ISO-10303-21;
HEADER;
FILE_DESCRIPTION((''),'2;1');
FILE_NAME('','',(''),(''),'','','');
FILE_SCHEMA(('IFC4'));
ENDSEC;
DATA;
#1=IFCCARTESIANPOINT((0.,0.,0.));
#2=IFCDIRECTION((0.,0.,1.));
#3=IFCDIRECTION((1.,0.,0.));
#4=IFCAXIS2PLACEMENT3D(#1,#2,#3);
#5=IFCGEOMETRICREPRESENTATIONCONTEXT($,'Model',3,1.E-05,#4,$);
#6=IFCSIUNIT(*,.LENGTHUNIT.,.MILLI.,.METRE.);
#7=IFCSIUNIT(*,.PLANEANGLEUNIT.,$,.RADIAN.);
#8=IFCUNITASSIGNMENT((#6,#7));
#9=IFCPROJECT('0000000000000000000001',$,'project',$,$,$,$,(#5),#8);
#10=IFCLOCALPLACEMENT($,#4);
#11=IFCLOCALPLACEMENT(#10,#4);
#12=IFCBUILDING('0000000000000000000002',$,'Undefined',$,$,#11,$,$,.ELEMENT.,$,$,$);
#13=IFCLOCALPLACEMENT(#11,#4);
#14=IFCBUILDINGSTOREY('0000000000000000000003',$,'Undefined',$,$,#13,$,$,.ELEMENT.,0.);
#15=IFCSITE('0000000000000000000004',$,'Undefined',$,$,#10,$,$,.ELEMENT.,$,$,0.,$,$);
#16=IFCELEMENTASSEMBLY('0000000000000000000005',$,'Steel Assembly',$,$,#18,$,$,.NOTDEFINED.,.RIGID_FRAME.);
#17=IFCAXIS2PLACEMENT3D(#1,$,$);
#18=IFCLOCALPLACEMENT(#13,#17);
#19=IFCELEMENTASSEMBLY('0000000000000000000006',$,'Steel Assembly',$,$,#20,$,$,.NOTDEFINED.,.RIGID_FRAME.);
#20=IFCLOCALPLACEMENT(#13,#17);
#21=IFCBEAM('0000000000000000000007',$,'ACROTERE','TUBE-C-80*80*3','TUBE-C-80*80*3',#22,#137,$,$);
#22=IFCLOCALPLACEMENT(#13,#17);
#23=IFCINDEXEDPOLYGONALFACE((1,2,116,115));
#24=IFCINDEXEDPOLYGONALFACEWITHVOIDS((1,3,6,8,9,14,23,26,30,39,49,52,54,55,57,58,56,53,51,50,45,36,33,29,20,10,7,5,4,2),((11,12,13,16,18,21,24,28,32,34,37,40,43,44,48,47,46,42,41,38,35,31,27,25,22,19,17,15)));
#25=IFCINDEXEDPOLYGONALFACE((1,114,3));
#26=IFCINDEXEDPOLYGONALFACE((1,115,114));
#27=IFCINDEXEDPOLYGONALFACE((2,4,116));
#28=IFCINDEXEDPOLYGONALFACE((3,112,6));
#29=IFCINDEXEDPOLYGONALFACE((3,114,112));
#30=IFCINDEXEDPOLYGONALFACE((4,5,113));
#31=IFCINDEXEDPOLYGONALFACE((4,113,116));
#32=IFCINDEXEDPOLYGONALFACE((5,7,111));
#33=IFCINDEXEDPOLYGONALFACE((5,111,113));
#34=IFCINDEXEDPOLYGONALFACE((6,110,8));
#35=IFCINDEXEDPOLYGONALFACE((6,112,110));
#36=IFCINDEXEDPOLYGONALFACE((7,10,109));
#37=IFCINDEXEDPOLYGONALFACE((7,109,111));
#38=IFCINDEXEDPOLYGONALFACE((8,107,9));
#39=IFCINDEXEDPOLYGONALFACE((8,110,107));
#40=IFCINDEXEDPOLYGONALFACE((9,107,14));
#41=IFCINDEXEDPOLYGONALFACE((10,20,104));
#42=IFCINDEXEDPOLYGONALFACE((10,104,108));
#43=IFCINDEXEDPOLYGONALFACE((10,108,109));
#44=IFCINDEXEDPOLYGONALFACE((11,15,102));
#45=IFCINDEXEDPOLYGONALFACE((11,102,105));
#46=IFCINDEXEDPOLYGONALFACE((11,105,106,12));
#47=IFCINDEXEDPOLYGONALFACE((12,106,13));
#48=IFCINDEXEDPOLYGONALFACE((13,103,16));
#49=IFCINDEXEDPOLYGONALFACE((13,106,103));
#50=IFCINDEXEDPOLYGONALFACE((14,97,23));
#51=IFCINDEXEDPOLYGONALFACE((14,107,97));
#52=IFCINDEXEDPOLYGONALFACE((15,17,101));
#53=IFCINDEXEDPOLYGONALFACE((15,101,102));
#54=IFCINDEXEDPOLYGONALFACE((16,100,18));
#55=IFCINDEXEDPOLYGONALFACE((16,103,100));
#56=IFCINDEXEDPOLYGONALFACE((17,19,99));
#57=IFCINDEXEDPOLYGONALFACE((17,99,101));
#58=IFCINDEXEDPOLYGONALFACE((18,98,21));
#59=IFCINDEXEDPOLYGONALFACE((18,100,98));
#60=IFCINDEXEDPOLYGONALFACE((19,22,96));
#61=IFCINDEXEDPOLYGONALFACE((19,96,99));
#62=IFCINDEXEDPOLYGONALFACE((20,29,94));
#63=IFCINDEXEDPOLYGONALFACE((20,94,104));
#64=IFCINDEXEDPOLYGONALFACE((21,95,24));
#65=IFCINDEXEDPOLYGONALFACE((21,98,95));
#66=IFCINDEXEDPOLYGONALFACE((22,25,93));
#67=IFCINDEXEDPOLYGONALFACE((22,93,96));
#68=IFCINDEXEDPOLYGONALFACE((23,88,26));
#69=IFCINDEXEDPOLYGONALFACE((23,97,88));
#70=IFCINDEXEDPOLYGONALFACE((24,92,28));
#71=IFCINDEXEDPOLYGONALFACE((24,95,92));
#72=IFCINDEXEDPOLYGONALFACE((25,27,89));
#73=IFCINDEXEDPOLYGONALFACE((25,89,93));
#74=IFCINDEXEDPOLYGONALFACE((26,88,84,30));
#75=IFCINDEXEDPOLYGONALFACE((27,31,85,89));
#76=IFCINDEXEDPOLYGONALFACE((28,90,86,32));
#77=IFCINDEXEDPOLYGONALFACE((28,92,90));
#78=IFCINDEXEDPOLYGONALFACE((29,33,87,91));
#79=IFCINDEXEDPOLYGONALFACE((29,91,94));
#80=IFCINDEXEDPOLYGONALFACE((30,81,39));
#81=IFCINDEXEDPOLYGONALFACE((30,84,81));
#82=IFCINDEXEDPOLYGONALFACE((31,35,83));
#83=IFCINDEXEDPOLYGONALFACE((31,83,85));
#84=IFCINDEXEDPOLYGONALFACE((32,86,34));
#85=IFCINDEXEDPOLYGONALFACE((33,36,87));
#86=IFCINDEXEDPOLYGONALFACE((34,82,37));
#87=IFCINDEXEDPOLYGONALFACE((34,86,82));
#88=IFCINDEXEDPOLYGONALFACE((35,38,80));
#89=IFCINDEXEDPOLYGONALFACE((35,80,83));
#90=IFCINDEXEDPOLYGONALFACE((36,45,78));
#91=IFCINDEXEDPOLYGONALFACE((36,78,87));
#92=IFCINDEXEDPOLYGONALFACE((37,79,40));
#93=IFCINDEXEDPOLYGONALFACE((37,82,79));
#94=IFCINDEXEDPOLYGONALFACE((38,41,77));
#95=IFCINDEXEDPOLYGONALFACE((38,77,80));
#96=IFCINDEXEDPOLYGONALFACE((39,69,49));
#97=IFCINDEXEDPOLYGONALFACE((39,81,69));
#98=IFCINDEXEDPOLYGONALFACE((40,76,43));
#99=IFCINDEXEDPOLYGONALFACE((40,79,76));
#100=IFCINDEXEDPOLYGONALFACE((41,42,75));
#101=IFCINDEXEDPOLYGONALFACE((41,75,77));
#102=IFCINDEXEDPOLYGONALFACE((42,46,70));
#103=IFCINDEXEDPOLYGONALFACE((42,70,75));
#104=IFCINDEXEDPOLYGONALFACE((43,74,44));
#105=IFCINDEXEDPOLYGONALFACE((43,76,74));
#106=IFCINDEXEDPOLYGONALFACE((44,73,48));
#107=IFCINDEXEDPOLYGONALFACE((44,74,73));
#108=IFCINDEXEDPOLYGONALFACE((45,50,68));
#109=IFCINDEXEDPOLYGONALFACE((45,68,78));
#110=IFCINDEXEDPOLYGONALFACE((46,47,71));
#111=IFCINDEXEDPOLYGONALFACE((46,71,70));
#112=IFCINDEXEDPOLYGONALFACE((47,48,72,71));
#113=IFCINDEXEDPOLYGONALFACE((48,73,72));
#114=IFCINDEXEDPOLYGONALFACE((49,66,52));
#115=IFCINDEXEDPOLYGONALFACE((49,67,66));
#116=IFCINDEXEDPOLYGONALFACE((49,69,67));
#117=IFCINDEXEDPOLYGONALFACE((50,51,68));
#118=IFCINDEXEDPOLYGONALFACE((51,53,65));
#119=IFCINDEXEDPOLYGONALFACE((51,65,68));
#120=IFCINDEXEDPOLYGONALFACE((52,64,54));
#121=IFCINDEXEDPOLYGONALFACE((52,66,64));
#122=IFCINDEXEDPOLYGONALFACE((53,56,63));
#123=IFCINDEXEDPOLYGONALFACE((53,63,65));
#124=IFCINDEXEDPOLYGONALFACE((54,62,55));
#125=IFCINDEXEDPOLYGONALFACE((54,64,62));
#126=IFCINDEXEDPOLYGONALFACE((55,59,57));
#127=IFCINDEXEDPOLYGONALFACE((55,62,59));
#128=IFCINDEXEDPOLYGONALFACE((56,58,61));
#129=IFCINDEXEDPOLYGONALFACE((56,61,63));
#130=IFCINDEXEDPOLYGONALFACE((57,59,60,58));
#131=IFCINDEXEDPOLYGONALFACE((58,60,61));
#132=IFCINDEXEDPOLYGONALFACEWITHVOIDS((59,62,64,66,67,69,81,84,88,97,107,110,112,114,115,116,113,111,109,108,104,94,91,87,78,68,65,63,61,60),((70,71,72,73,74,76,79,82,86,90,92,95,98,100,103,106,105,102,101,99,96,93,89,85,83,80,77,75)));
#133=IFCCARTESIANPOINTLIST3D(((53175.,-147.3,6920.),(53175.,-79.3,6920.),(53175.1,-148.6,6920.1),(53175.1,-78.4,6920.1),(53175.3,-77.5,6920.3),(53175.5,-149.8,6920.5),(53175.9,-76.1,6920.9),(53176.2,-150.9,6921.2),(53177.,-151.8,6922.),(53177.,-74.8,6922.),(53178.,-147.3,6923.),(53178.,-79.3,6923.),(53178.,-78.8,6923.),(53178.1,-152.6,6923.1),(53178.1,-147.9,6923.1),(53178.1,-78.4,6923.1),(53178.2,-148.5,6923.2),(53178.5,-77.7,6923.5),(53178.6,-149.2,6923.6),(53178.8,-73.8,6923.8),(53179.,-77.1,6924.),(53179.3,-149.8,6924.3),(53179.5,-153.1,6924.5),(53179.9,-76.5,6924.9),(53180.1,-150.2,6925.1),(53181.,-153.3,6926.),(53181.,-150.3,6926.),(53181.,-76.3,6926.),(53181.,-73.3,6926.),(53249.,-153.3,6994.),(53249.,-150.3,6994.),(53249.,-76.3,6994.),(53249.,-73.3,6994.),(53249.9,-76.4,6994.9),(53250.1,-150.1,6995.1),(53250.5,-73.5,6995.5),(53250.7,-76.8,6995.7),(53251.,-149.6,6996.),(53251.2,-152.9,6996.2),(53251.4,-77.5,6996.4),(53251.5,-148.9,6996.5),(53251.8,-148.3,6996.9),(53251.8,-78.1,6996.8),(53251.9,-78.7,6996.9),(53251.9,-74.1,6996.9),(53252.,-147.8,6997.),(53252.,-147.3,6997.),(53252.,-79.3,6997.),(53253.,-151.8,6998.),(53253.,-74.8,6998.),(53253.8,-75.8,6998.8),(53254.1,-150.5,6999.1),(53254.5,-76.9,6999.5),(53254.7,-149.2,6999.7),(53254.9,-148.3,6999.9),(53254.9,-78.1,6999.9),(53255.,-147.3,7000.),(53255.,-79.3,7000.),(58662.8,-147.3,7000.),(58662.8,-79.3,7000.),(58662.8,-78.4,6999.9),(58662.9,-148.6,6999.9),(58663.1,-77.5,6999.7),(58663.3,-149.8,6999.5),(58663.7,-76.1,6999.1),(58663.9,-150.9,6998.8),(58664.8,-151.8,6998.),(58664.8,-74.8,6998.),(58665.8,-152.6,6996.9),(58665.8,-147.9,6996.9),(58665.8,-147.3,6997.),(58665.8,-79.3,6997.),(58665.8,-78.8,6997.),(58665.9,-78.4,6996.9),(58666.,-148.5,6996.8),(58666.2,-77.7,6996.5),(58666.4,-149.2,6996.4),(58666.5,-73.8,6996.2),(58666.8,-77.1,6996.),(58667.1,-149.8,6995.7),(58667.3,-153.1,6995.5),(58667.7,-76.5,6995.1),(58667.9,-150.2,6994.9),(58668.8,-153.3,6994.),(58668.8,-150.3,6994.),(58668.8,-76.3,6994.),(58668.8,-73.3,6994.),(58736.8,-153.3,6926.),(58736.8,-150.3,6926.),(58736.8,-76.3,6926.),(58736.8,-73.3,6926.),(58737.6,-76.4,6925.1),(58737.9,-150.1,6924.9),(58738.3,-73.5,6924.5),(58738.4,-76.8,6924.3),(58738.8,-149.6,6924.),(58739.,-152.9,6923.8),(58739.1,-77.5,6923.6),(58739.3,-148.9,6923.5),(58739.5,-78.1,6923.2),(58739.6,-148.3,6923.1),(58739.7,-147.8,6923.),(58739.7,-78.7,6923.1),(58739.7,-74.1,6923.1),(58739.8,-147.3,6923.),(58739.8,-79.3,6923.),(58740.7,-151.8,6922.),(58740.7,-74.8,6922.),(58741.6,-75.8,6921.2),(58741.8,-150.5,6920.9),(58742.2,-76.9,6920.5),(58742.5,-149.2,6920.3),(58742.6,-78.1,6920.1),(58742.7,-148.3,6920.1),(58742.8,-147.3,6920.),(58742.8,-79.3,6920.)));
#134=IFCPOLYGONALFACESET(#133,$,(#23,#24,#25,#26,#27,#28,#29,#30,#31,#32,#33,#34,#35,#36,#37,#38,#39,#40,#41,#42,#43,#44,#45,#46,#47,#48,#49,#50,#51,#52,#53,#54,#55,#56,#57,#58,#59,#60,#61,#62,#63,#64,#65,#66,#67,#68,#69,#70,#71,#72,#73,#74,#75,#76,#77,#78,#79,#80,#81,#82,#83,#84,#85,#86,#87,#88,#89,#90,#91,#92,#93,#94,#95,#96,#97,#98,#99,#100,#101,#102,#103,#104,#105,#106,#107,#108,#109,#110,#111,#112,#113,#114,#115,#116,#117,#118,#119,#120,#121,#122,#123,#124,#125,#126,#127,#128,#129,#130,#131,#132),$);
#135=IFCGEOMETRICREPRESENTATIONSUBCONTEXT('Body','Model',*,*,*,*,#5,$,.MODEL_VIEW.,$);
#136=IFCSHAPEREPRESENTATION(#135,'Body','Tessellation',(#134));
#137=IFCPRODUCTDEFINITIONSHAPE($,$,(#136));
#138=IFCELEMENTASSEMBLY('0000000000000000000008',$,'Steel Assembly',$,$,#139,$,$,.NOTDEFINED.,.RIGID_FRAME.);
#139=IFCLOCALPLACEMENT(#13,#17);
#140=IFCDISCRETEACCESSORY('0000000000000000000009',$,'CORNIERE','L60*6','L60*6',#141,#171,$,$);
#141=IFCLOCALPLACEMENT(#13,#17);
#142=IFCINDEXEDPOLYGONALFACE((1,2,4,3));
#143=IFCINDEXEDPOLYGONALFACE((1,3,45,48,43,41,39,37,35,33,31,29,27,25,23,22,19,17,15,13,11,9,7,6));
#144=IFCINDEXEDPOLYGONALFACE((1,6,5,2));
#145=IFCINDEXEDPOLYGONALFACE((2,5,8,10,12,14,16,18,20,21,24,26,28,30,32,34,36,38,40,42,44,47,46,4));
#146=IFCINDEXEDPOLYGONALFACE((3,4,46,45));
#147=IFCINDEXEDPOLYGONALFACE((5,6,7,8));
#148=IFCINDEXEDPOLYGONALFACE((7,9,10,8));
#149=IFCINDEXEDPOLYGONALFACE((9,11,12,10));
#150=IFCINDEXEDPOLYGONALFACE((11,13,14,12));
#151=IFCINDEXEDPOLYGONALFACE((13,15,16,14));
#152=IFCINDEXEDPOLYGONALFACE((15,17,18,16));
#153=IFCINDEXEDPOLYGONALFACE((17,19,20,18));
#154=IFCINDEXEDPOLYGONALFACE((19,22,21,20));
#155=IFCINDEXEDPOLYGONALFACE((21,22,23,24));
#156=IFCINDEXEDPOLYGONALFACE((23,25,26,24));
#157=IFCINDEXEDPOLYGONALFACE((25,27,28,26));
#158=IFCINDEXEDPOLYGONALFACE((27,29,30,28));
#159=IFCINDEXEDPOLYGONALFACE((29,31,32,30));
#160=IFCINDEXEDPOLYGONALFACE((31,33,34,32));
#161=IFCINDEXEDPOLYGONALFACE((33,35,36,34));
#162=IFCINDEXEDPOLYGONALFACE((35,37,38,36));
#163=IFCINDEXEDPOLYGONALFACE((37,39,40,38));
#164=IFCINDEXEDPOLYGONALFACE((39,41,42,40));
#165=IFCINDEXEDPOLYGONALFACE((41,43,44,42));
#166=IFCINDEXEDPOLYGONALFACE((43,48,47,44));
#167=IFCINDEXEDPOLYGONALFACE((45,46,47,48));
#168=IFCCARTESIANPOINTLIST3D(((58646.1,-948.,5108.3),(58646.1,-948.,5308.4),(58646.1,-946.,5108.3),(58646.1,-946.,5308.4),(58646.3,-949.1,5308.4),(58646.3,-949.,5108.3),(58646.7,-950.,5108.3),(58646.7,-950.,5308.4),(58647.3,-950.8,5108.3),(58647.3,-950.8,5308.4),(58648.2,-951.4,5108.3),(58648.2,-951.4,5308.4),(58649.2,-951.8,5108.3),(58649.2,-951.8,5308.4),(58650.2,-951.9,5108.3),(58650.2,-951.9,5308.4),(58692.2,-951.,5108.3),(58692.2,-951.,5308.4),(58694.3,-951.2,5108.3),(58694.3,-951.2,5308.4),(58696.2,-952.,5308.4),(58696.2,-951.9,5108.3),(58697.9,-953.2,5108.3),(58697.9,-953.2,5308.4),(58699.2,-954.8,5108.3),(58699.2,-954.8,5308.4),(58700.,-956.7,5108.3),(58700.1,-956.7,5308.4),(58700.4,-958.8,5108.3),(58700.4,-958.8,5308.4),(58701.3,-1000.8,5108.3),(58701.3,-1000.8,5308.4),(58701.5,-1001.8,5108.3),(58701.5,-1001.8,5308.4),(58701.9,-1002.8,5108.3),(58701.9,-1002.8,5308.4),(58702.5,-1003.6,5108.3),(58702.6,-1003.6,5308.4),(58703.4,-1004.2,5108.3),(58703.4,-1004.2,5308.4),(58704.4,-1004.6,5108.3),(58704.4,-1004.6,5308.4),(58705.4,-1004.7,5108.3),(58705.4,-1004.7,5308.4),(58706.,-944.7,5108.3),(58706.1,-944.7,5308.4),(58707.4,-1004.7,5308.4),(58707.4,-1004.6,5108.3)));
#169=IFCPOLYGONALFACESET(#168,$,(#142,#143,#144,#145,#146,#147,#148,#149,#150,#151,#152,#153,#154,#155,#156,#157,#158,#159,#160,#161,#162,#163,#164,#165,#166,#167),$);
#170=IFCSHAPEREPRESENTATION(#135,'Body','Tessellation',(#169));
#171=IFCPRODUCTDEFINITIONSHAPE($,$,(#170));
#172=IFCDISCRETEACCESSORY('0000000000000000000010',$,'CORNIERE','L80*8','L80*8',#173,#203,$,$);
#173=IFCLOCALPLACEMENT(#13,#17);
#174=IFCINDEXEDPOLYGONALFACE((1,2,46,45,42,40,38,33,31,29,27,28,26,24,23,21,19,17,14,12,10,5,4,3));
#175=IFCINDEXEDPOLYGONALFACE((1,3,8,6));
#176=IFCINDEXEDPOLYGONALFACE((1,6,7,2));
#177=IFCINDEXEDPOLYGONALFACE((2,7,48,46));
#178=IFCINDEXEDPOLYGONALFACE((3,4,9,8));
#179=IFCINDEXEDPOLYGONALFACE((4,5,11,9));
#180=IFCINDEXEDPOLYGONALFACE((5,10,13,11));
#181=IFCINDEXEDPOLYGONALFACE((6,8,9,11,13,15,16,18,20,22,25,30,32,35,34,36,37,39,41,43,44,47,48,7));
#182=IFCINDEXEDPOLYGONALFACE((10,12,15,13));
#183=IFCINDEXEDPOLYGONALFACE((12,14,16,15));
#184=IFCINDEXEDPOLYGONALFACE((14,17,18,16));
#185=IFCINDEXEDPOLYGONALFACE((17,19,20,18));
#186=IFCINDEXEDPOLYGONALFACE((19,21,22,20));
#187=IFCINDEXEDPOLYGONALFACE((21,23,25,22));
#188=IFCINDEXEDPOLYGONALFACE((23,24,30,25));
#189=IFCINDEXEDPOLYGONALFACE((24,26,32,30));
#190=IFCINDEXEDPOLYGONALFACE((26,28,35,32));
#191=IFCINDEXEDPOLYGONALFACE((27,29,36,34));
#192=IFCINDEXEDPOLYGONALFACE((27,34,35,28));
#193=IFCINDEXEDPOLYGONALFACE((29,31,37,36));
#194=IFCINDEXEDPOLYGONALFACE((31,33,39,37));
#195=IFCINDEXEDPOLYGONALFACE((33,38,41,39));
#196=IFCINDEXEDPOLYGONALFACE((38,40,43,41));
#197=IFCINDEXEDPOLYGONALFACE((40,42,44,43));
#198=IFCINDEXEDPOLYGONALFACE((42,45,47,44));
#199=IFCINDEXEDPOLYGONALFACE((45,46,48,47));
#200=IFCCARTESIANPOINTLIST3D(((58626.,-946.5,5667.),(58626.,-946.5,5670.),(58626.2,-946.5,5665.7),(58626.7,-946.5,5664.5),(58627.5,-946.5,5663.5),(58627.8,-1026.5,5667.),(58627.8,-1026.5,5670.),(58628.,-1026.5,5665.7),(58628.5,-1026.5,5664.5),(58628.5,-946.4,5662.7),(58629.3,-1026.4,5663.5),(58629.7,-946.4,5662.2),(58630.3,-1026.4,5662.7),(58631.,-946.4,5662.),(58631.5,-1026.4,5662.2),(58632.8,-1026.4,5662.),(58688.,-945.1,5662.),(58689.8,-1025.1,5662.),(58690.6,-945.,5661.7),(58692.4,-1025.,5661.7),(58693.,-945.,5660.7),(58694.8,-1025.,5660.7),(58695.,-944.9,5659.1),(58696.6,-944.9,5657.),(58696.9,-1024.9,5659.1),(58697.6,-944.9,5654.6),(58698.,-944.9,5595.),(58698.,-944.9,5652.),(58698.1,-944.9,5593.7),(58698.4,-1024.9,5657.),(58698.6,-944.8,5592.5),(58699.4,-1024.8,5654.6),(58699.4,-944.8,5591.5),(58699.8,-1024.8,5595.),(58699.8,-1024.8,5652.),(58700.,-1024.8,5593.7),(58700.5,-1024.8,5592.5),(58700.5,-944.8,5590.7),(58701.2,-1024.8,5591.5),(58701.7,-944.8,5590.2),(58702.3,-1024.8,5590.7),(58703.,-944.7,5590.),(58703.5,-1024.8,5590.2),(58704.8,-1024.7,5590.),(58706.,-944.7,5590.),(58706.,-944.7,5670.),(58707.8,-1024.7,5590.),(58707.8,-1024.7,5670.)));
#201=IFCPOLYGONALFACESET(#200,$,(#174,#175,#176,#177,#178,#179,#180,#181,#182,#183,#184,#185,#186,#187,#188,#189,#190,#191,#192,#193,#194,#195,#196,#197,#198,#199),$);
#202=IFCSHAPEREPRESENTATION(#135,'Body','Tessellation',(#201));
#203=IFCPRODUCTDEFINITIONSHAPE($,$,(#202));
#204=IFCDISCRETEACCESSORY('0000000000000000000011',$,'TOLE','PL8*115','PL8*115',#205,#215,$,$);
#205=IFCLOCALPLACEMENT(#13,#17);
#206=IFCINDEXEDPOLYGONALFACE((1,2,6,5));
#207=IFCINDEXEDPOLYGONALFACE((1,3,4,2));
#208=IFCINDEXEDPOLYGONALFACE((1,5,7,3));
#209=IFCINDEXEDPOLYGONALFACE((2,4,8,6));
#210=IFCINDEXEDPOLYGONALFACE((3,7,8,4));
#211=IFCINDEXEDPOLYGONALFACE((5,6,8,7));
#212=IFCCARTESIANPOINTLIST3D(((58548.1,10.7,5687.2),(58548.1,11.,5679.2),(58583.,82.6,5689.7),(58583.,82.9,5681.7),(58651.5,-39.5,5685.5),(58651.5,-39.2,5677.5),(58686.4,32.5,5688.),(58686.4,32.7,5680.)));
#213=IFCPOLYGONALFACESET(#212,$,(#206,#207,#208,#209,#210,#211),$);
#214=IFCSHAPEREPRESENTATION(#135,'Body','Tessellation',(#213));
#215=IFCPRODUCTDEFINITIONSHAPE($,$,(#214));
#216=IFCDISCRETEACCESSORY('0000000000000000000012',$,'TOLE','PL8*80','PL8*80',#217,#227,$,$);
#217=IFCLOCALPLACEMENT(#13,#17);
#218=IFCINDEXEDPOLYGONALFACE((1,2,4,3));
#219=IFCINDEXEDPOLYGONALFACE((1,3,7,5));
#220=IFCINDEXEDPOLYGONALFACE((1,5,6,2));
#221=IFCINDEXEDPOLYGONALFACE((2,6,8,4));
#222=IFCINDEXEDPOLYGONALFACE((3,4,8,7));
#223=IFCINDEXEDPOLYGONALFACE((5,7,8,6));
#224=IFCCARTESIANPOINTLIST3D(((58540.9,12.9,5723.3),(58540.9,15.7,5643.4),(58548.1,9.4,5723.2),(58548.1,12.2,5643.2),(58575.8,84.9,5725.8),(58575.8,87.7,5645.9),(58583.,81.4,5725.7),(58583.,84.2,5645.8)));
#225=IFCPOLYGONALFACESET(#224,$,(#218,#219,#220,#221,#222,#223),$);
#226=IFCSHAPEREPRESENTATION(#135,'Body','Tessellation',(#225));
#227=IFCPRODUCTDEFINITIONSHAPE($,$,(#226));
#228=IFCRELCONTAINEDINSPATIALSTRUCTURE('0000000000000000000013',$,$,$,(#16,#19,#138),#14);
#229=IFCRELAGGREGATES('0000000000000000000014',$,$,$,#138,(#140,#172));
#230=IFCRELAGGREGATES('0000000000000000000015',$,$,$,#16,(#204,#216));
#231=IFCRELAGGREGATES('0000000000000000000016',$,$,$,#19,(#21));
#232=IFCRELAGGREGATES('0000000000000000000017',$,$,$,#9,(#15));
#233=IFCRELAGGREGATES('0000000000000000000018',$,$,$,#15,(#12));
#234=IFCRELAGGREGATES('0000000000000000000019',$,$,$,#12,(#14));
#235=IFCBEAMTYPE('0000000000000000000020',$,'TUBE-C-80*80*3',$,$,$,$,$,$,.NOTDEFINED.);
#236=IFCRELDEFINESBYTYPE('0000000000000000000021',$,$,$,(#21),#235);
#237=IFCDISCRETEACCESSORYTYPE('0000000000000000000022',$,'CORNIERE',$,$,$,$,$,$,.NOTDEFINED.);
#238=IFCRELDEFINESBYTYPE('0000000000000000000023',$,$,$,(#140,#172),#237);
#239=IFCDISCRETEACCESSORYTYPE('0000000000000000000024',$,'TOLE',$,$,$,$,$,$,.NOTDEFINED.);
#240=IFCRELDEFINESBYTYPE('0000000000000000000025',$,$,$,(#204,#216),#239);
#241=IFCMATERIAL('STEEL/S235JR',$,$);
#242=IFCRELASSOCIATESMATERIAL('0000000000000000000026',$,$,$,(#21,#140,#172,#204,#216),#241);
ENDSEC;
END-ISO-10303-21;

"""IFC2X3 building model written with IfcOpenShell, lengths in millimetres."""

from ifc_helpers import new_model, si_unit, frame, origin_with_axes, origin_2d_with_axis, place, context, subcontext, project, spatial, polyline, hollow_rectangle, l_section, outline, extrude, clip, halfspace, material, type_object, element, aggregate, save


model = new_model("IFC2X3")

# Units and contexts
model_context = context("Model", 3, precision=1e-05, world=origin_with_axes())
body_context = subcontext(model_context, "Body", "Model", "MODEL_VIEW")
ifc_project = project(units=[si_unit("LENGTHUNIT", "METRE", prefix="MILLI"), si_unit("PLANEANGLEUNIT", "RADIAN")], contexts=[model_context])

# Site, building, storey
site_placement = place(None, origin_with_axes())
site = spatial("IfcSite", under=ifc_project, at=site_placement, Name="Undefined", CompositionType="ELEMENT", RefElevation=0.0)
building_placement = place(site_placement, origin_with_axes())
building = spatial("IfcBuilding", under=site, at=building_placement, Name="Undefined", CompositionType="ELEMENT")
storey_placement = place(building_placement, origin_with_axes())
storey = spatial("IfcBuildingStorey", under=building, at=storey_placement, Name="Undefined", CompositionType="ELEMENT", Elevation=0.0)

# Element assemblies, beam
ifc_material_1 = material(Name="STEEL/S235JR")
beam_type_1 = type_object("IfcBeamType", Name="TUBE-C-80*80*3", PredefinedType="NOTDEFINED")
assembly_1_placement = place(storey_placement, origin_with_axes())
assembly_1 = element("IfcElementAssembly", 1, at=assembly_1_placement, inside=storey, Name="Steel Assembly", AssemblyPlace="NOTDEFINED", PredefinedType="RIGID_FRAME")
assembly_2_placement = place(storey_placement, origin_with_axes())
assembly_2 = element("IfcElementAssembly", 2, at=assembly_2_placement, inside=storey, Name="Steel Assembly", AssemblyPlace="NOTDEFINED", PredefinedType="RIGID_FRAME")
beam_1_placement = place(assembly_2_placement, frame((58747.8, -113.3, 6960.0), z_axis=(0.0, 0.0, -1.0), x_axis=(-1.0, 0.0, 0.0)))
beam_1 = element("IfcBeam", 3, at=beam_1_placement, type_object=beam_type_1, material=ifc_material_1, Name="ACROTERE", Description="TUBE-C-80*80*3", ObjectType="TUBE-C-80*80*3", context=body_context, shape_type="Clipping", body=[
    clip(clip(extrude(hollow_rectangle(XDim=80.0, YDim=80.0, WallThickness=3.0, InnerFilletRadius=3.0, OuterFilletRadius=6.0, at=origin_2d_with_axis()), frame((5577.8, 0.0, 0.0), z_axis=(-1.0, 0.0, 0.0), x_axis=(0.0, -1.0, 0.0)), (0.0, 0.0, 1.0), 5577.8), halfspace(frame((5.0, -40.0, 40.0), z_axis=(-0.707107, 0.0, -0.707107), x_axis=(0.707107, 0.0, -0.707107)), False)), halfspace(frame((5572.8, 40.0, 40.0), z_axis=(0.707107, 0.0, -0.707107), x_axis=(-0.707107, 0.0, -0.707107)), False)),
])

# Element assembly, discrete accessories
assembly_3_placement = place(storey_placement, origin_with_axes())
assembly_3 = element("IfcElementAssembly", 4, at=assembly_3_placement, inside=storey, Name="Steel Assembly", AssemblyPlace="NOTDEFINED", PredefinedType="RIGID_FRAME")
discrete_accessory_type_1 = type_object("IfcDiscreteAccessoryType", Name="CORNIERE")
discrete_accessory_1_placement = place(assembly_3_placement, frame((58676.7, -975.3, 5308.4), z_axis=(0.022588, -0.999745, -0.000079), x_axis=(-0.000026, 0.000079, -1.0)))
discrete_accessory_1 = element("IfcDiscreteAccessory", 5, at=discrete_accessory_1_placement, type_object=discrete_accessory_type_1, material=ifc_material_1, Name="CORNIERE", Description="L60*6", ObjectType="L60*6", context=body_context, shape_type="SweptSolid", body=[
    extrude(l_section(Depth=60.0, Width=60.0, Thickness=6.0, FilletRadius=8.0, EdgeRadius=4.0, at=origin_2d_with_axis()), frame((200.1, 0.0, 0.0), z_axis=(-1.0, 0.0, 0.0), x_axis=(0.0, -1.0, 0.0)), (0.0, 0.0, 1.0), 200.1),
])
discrete_accessory_2_placement = place(assembly_3_placement, frame((58667.8, -1025.6, 5630.0), z_axis=(0.0, 0.0, -1.0), x_axis=(-0.022588, 0.999745, -0.000001)))
discrete_accessory_2 = element("IfcDiscreteAccessory", 6, at=discrete_accessory_2_placement, type_object=discrete_accessory_type_1, material=ifc_material_1, Name="CORNIERE", Description="L80*8", ObjectType="L80*8", context=body_context, shape_type="SweptSolid", body=[
    extrude(l_section(Depth=80.0, Width=80.0, Thickness=8.0, FilletRadius=10.0, EdgeRadius=5.0, at=origin_2d_with_axis()), frame((80.0, 0.0, 0.0), z_axis=(-1.0, 0.0, 0.0), x_axis=(0.0, -1.0, 0.0)), (0.0, 0.0, 1.0), 80.0),
])

# Discrete accessories
discrete_accessory_type_2 = type_object("IfcDiscreteAccessoryType", Name="TOLE")
discrete_accessory_3_placement = place(assembly_1_placement, frame((58599.8, -14.2, 5682.3), z_axis=(0.0, 0.034979, -0.999388), x_axis=(0.436481, 0.899163, 0.031471)))
discrete_accessory_3 = element("IfcDiscreteAccessory", 7, at=discrete_accessory_3_placement, type_object=discrete_accessory_type_2, material=ifc_material_1, Name="TOLE", Description="PL8*115", ObjectType="PL8*115", context=body_context, shape_type="SweptSolid", body=[
    extrude(outline(polyline([(0.0, 57.5), (80.0, 57.5), (80.0, -57.5), (0.0, -57.5), (0.0, 57.5)])), frame((0.0, 0.0, -4.0), z_axis=(0.0, 0.0, 1.0), x_axis=(1.0, 0.0, 0.0)), (0.0, 0.0, 1.0), 8.0),
])
discrete_accessory_4_placement = place(assembly_1_placement, frame((58544.5, 12.6, 5683.3), z_axis=(0.899713, -0.436214, -0.015267), x_axis=(0.436481, 0.899163, 0.031471)))
discrete_accessory_4 = element("IfcDiscreteAccessory", 8, at=discrete_accessory_4_placement, type_object=discrete_accessory_type_2, material=ifc_material_1, Name="TOLE", Description="PL8*80", ObjectType="PL8*80", context=body_context, shape_type="SweptSolid", body=[
    extrude(outline(polyline([(80.0, 40.0), (80.0, -40.0), (0.0, -40.0), (0.0, 40.0), (80.0, 40.0)])), frame((0.0, 0.0, -4.0), z_axis=(0.0, 0.0, 1.0), x_axis=(1.0, 0.0, 0.0)), (0.0, 0.0, 1.0), 8.0),
])

aggregate(assembly_3, [discrete_accessory_1, discrete_accessory_2])

aggregate(assembly_1, [discrete_accessory_3, discrete_accessory_4])

aggregate(assembly_2, [beam_1])

save(model, "model.ifc")
